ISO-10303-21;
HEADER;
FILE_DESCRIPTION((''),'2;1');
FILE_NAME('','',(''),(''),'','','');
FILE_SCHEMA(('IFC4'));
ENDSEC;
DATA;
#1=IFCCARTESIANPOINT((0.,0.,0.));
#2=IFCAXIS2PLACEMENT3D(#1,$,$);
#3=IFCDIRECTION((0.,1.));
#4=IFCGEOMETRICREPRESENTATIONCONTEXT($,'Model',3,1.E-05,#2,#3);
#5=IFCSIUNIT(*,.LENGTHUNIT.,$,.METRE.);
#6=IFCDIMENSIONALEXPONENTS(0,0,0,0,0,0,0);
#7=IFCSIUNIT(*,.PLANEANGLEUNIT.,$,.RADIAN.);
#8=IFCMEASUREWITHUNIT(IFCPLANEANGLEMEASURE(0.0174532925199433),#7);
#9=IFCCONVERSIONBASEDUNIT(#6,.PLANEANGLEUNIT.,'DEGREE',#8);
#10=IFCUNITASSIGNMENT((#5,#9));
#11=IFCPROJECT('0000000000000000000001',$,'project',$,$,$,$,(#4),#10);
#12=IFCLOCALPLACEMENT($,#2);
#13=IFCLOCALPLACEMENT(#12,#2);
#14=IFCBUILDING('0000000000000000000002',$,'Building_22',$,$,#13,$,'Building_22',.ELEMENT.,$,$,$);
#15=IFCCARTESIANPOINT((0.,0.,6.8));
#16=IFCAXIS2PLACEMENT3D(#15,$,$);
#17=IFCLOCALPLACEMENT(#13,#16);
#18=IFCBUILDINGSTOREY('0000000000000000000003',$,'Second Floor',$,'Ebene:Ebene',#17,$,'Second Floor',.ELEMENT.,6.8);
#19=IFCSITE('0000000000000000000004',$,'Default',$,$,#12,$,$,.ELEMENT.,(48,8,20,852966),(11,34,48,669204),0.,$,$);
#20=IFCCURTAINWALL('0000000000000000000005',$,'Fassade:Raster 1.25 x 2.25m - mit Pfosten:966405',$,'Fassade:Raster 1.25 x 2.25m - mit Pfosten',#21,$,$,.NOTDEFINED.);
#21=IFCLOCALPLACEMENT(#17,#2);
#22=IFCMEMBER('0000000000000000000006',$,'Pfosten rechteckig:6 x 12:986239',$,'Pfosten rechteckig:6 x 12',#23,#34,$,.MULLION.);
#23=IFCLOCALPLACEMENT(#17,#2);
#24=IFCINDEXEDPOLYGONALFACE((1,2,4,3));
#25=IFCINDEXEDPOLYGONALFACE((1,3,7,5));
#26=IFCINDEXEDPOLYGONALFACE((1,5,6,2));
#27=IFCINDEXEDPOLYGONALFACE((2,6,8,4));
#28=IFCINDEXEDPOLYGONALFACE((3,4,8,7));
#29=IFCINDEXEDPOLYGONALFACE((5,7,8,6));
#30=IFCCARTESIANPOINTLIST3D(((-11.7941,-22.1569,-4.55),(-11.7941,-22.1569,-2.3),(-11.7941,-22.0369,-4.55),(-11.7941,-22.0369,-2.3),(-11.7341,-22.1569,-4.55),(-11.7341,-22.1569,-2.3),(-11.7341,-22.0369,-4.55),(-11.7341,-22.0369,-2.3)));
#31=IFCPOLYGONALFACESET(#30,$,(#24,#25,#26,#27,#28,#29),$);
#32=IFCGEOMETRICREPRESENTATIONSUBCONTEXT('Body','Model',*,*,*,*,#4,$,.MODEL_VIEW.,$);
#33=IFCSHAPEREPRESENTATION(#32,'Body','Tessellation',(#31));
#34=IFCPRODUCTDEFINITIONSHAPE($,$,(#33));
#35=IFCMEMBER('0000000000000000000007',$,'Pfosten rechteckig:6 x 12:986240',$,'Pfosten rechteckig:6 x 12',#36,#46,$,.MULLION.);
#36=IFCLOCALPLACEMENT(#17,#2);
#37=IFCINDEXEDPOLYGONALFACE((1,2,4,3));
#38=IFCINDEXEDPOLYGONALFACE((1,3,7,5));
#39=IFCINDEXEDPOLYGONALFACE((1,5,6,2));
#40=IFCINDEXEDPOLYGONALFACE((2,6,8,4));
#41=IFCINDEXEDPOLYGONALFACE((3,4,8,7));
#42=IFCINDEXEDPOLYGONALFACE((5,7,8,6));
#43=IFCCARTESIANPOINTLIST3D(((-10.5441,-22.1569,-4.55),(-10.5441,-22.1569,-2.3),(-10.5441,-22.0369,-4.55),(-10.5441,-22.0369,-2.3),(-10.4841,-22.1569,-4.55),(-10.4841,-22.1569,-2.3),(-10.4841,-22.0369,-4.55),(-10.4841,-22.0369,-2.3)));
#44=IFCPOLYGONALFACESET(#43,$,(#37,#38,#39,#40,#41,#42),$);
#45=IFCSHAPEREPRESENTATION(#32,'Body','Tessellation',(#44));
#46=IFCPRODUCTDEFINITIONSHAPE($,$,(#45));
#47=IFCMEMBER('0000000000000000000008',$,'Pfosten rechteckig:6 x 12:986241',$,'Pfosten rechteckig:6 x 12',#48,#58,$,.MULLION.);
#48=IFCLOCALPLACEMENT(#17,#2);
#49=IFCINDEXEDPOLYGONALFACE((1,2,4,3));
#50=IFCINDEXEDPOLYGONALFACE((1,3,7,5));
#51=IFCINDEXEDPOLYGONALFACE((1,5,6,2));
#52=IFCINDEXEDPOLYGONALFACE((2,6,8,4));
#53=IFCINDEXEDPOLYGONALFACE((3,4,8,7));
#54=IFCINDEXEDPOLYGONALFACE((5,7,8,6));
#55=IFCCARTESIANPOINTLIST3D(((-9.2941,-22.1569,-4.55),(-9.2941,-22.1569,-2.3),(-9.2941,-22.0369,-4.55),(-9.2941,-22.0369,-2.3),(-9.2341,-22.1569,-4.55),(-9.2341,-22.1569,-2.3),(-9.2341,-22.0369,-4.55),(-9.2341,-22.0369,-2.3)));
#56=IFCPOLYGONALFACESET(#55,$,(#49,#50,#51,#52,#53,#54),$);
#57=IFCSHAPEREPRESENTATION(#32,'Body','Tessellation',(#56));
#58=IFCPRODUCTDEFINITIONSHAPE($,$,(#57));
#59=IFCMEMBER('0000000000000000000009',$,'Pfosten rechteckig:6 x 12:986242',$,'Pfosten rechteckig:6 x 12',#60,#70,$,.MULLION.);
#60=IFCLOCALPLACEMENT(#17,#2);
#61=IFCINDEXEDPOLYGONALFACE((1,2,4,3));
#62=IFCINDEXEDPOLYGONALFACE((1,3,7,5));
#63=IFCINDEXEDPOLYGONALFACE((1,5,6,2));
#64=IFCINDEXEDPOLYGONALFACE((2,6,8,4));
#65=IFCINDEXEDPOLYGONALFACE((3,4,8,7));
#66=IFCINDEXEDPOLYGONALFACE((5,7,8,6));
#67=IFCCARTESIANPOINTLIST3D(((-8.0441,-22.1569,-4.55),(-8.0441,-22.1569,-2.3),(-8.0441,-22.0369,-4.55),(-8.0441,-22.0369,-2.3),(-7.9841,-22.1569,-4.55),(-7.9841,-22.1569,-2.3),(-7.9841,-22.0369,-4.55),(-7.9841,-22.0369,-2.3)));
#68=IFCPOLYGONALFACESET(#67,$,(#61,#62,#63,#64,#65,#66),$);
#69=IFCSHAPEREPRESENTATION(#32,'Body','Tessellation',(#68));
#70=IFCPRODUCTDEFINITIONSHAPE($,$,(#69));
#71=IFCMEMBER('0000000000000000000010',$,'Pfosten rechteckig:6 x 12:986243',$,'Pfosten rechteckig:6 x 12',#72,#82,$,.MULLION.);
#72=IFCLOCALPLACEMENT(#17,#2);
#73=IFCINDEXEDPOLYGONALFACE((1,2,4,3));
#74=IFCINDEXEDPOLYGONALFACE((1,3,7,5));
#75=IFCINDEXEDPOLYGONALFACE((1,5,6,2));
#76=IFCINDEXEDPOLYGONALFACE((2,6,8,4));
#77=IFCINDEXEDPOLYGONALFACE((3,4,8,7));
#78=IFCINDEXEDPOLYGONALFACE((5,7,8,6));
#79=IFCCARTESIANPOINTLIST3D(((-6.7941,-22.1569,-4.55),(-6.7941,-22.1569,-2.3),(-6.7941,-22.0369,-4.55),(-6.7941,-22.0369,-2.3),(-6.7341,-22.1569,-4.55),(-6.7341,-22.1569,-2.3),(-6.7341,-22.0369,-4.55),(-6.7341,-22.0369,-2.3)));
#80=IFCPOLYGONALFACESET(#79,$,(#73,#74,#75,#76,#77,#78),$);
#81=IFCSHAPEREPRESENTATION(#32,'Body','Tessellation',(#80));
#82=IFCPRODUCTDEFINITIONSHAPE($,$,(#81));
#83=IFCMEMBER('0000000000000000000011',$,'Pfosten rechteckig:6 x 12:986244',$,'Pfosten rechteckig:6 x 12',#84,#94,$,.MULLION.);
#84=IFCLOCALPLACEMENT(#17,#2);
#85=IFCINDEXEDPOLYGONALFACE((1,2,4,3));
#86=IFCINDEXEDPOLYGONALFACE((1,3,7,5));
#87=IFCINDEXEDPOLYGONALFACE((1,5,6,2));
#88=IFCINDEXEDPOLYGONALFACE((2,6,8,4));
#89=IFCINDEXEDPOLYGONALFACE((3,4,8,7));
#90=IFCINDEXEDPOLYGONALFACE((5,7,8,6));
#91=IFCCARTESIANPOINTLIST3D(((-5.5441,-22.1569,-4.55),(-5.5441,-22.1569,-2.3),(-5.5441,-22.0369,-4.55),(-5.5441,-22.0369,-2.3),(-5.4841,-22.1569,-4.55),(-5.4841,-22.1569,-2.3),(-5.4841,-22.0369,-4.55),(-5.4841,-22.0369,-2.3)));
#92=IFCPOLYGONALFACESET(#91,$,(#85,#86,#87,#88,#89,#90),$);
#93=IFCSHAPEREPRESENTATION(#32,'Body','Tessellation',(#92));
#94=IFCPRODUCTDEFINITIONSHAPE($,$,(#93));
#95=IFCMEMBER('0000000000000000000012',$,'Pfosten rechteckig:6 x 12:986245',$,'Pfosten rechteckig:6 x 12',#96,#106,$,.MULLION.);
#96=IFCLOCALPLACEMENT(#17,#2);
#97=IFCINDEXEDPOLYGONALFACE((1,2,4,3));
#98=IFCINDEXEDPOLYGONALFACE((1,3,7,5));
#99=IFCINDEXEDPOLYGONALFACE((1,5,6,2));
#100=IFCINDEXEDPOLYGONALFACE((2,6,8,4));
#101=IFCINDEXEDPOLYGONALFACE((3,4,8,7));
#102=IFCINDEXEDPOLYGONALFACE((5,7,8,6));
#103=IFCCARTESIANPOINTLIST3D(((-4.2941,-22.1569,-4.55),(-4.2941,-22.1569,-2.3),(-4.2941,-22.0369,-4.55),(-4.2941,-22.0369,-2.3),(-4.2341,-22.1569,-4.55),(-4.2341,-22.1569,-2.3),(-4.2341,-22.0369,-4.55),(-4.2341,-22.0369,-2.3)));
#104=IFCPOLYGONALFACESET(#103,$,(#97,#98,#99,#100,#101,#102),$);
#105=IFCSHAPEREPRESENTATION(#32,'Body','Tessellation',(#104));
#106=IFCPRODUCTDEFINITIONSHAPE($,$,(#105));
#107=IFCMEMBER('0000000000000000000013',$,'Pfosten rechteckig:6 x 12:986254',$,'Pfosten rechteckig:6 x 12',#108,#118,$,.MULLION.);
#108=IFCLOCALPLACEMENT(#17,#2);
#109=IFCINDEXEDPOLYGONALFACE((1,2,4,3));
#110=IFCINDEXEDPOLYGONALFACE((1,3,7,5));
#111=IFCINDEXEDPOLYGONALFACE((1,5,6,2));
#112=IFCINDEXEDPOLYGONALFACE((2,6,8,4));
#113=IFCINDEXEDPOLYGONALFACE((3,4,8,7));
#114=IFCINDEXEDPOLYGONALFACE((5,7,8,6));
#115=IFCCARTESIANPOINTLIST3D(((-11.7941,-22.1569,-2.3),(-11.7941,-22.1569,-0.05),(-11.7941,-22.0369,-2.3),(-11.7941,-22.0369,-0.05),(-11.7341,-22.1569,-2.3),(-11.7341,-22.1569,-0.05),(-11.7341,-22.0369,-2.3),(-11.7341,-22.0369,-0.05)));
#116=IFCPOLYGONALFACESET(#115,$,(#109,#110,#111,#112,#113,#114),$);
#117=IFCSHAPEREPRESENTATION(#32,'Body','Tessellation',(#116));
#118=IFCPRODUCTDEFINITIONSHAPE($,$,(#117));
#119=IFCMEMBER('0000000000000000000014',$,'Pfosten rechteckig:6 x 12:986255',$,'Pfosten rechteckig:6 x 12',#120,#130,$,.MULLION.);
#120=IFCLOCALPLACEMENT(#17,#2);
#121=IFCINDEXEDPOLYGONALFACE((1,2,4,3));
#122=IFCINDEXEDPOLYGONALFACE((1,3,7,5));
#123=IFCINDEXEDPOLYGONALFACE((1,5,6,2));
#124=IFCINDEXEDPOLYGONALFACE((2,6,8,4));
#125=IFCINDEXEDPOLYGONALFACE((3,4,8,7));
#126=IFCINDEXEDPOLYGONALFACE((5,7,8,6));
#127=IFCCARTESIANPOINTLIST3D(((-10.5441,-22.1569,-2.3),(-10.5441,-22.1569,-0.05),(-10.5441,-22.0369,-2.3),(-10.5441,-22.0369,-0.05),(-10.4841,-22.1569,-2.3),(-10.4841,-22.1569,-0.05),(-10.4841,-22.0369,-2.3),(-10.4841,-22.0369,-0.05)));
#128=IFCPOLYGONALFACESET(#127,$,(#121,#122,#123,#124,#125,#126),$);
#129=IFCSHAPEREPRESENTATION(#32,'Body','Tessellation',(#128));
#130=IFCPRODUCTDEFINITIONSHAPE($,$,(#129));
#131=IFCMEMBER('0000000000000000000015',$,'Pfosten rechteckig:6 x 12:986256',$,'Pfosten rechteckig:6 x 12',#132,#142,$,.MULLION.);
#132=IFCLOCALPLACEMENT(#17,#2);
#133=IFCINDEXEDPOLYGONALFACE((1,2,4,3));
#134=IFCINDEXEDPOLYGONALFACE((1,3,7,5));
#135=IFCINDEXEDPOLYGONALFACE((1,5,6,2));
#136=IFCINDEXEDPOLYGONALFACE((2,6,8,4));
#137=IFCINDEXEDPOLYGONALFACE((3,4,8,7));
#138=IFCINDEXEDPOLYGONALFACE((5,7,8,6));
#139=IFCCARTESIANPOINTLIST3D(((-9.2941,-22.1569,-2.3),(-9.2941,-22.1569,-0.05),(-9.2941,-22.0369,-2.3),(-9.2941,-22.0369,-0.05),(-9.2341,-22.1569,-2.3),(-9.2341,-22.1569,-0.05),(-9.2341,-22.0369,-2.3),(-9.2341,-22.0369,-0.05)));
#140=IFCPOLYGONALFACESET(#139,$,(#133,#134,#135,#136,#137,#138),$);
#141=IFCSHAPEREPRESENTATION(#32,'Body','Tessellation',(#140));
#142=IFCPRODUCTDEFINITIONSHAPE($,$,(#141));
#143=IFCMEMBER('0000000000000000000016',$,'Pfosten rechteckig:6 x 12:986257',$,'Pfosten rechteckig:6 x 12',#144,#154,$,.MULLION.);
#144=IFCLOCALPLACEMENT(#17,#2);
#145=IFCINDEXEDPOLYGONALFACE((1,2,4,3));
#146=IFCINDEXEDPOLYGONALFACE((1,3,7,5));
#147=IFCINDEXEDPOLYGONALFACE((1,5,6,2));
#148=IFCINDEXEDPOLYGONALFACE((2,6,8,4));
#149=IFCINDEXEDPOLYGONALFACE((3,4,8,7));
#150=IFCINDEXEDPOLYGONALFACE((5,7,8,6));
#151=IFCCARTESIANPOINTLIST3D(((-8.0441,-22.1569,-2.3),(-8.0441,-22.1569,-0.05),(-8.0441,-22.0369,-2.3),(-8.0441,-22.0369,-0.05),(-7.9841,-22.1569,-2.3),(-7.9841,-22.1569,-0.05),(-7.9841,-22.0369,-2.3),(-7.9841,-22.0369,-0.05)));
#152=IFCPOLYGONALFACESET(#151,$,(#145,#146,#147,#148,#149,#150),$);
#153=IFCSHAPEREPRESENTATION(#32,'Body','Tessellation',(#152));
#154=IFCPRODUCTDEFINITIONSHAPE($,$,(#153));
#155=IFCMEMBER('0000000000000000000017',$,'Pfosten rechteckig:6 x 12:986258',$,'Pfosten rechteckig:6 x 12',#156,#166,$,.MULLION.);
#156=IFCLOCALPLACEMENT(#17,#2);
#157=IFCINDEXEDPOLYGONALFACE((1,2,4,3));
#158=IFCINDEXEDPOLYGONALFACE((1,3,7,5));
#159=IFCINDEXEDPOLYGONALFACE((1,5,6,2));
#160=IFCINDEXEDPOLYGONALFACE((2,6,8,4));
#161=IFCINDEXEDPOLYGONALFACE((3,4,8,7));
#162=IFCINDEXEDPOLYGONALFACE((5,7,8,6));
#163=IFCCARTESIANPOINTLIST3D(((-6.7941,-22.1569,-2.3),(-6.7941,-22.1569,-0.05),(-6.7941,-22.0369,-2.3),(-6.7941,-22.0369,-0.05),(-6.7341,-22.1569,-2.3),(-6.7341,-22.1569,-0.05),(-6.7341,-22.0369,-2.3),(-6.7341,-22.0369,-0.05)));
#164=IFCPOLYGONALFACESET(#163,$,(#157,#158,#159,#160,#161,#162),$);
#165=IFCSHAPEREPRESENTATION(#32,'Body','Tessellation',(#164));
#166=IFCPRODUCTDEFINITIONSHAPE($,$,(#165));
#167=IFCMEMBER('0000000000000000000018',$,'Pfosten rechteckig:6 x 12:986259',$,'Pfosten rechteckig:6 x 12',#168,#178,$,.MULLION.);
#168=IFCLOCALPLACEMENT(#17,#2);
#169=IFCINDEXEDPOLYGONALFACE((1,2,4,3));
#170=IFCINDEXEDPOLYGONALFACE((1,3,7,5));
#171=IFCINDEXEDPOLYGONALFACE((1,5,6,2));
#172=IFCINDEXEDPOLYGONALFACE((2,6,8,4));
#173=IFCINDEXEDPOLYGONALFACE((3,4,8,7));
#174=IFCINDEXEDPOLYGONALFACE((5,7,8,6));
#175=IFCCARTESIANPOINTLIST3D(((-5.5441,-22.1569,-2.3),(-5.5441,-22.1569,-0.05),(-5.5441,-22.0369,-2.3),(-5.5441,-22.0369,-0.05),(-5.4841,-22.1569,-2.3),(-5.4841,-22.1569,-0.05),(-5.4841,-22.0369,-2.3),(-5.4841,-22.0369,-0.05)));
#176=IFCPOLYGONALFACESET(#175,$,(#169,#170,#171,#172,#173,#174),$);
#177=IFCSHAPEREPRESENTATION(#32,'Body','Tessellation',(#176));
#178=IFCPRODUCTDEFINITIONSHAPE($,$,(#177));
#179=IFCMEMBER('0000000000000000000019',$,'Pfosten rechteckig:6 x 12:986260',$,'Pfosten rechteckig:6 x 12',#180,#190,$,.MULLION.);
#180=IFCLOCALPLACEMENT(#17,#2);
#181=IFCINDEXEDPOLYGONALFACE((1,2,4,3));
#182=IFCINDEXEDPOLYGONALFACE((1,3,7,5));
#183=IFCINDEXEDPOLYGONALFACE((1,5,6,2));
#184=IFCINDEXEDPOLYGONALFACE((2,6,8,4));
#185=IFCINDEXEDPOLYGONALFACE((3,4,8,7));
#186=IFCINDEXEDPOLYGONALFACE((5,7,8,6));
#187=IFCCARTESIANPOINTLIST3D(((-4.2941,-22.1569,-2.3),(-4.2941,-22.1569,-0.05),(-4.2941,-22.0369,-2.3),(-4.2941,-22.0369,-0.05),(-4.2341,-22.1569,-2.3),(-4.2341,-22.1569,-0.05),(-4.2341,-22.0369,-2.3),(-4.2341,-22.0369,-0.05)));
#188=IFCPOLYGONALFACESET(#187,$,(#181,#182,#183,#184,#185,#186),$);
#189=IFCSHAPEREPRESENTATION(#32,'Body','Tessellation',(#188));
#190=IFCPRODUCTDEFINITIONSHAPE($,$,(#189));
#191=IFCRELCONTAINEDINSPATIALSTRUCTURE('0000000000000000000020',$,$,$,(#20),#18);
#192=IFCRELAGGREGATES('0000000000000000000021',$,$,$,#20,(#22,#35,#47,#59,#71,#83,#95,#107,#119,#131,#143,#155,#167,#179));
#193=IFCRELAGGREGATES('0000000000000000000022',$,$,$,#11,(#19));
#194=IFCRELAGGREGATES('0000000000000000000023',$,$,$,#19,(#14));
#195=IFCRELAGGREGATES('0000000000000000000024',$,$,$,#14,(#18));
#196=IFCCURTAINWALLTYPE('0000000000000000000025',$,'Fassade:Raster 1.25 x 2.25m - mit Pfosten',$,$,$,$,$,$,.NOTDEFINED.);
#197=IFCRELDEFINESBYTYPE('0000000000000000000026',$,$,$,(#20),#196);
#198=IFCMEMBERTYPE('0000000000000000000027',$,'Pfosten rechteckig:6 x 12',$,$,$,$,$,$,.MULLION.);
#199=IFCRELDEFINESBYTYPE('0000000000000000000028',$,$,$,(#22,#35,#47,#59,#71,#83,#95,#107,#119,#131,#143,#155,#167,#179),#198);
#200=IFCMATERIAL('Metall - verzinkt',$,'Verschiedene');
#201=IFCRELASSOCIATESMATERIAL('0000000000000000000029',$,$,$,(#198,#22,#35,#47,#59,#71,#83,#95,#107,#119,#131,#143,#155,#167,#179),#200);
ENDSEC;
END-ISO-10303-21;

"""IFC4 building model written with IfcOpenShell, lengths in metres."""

from ifc_helpers import new_model, entity, si_unit, converted_unit, direction, frame, origin, place, context, subcontext, project, spatial, indexed_curve, outline, extrude, source, transform, mapped, material, type_object, type_shapes, element, aggregate, save


model = new_model("IFC4")

# Units and contexts
model_context = context("Model", 3, precision=1e-05, world=origin(), true_north=direction((0.0, 1.0)))
body_context = subcontext(model_context, "Body", "Model", "MODEL_VIEW")
ifc_project = project(units=[si_unit("LENGTHUNIT", "METRE"), converted_unit("PLANEANGLEUNIT", "DEGREE", entity("IfcPlaneAngleMeasure", 0.0174532925199433), si_unit("PLANEANGLEUNIT", "RADIAN"), dimensions=[0, 0, 0, 0, 0, 0, 0])], contexts=[model_context])

# Site, building, storey
site_placement = place(None, origin())
site = spatial("IfcSite", under=ifc_project, at=site_placement, Name="Default", CompositionType="ELEMENT", RefLatitude=(48, 8, 20, 852966), RefLongitude=(11, 34, 48, 669204), RefElevation=0.0)
building_placement = place(site_placement, origin())
building = spatial("IfcBuilding", under=site, at=building_placement, Name="Building_22", LongName="Building_22", CompositionType="ELEMENT")
storey_placement = place(building_placement, frame((0.0, 0.0, 6.8)))
storey = spatial("IfcBuildingStorey", under=building, at=storey_placement, Name="Second Floor", ObjectType="Ebene:Ebene", LongName="Second Floor", CompositionType="ELEMENT", Elevation=6.8)

# Curtain wall, members
curtain_wall_type = type_object("IfcCurtainWallType", Name="Fassade:Raster 1.25 x 2.25m - mit Pfosten", PredefinedType="NOTDEFINED")
curtain_wall_placement = place(storey_placement, frame((0.0, 0.0, -6.8)))
curtain_wall = element("IfcCurtainWall", 1, at=curtain_wall_placement, inside=storey, type_object=curtain_wall_type, Name="Fassade:Raster 1.25 x 2.25m - mit Pfosten:966405", ObjectType="Fassade:Raster 1.25 x 2.25m - mit Pfosten", PredefinedType="NOTDEFINED")
ifc_material = material(Name="Metall - verzinkt", Category="Verschiedene")
member_type_1 = type_object("IfcMemberType", Name="Pfosten rechteckig:6 x 12", PredefinedType="MULLION", material=ifc_material)
shared_shape_1 = source(origin(), body_context, "Body", "SweptSolid", [
    extrude(outline(indexed_curve([(-0.03, -0.06), (0.03, -0.06), (0.03, 0.06), (-0.03, 0.06), (-0.03, -0.06)], self_intersect=False)), frame((0.0, 0.0, -2.25), z_axis=(0.0, 0.0, 1.0), x_axis=(-1.0, 0.0, 0.0)), (0.0, 0.0, 1.0), 2.25),
])
type_shapes(member_type_1, [shared_shape_1])
member_1_placement = place(curtain_wall_placement, frame((-11.7641, -22.0969, 2.25), z_axis=(0.0, 0.0, -1.0), x_axis=(1.0, 0.0, 0.0)))
member_1 = element("IfcMember", 2, at=member_1_placement, type_object=member_type_1, material=ifc_material, Name="Pfosten rechteckig:6 x 12:986239", ObjectType="Pfosten rechteckig:6 x 12", PredefinedType="MULLION", context=body_context, shape_type="MappedRepresentation", body=[
    mapped(shared_shape_1, transform((0.0, 0.0, 0.0), scale=1.0)),
])
member_2_placement = place(curtain_wall_placement, frame((-10.5141, -22.0969, 2.25), z_axis=(0.0, 0.0, -1.0), x_axis=(1.0, 0.0, 0.0)))
member_2 = element("IfcMember", 3, at=member_2_placement, type_object=member_type_1, material=ifc_material, Name="Pfosten rechteckig:6 x 12:986240", ObjectType="Pfosten rechteckig:6 x 12", PredefinedType="MULLION", context=body_context, shape_type="MappedRepresentation", body=[
    mapped(shared_shape_1, transform((0.0, 0.0, 0.0), scale=1.0)),
])
member_3_placement = place(curtain_wall_placement, frame((-9.2641, -22.0969, 2.25), z_axis=(0.0, 0.0, -1.0), x_axis=(1.0, 0.0, 0.0)))
member_3 = element("IfcMember", 4, at=member_3_placement, type_object=member_type_1, material=ifc_material, Name="Pfosten rechteckig:6 x 12:986241", ObjectType="Pfosten rechteckig:6 x 12", PredefinedType="MULLION", context=body_context, shape_type="MappedRepresentation", body=[
    mapped(shared_shape_1, transform((0.0, 0.0, 0.0), scale=1.0)),
])
member_4_placement = place(curtain_wall_placement, frame((-8.0141, -22.0969, 2.25), z_axis=(0.0, 0.0, -1.0), x_axis=(1.0, 0.0, 0.0)))
member_4 = element("IfcMember", 5, at=member_4_placement, type_object=member_type_1, material=ifc_material, Name="Pfosten rechteckig:6 x 12:986242", ObjectType="Pfosten rechteckig:6 x 12", PredefinedType="MULLION", context=body_context, shape_type="MappedRepresentation", body=[
    mapped(shared_shape_1, transform((0.0, 0.0, 0.0), scale=1.0)),
])
member_5_placement = place(curtain_wall_placement, frame((-6.7641, -22.0969, 2.25), z_axis=(0.0, 0.0, -1.0), x_axis=(1.0, 0.0, 0.0)))
member_5 = element("IfcMember", 6, at=member_5_placement, type_object=member_type_1, material=ifc_material, Name="Pfosten rechteckig:6 x 12:986243", ObjectType="Pfosten rechteckig:6 x 12", PredefinedType="MULLION", context=body_context, shape_type="MappedRepresentation", body=[
    mapped(shared_shape_1, transform((0.0, 0.0, 0.0), scale=1.0)),
])
member_6_placement = place(curtain_wall_placement, frame((-5.5141, -22.0969, 2.25), z_axis=(0.0, 0.0, -1.0), x_axis=(1.0, 0.0, 0.0)))
member_6 = element("IfcMember", 7, at=member_6_placement, type_object=member_type_1, material=ifc_material, Name="Pfosten rechteckig:6 x 12:986244", ObjectType="Pfosten rechteckig:6 x 12", PredefinedType="MULLION", context=body_context, shape_type="MappedRepresentation", body=[
    mapped(shared_shape_1, transform((0.0, 0.0, 0.0), scale=1.0)),
])
member_7_placement = place(curtain_wall_placement, frame((-4.2641, -22.0969, 2.25), z_axis=(0.0, 0.0, -1.0), x_axis=(1.0, 0.0, 0.0)))
member_7 = element("IfcMember", 8, at=member_7_placement, type_object=member_type_1, material=ifc_material, Name="Pfosten rechteckig:6 x 12:986245", ObjectType="Pfosten rechteckig:6 x 12", PredefinedType="MULLION", context=body_context, shape_type="MappedRepresentation", body=[
    mapped(shared_shape_1, transform((0.0, 0.0, 0.0), scale=1.0)),
])
member_8_placement = place(curtain_wall_placement, frame((-11.7641, -22.0969, 4.5), z_axis=(0.0, 0.0, -1.0), x_axis=(1.0, 0.0, 0.0)))
member_8 = element("IfcMember", 9, at=member_8_placement, type_object=member_type_1, material=ifc_material, Name="Pfosten rechteckig:6 x 12:986254", ObjectType="Pfosten rechteckig:6 x 12", PredefinedType="MULLION", context=body_context, shape_type="MappedRepresentation", body=[
    mapped(shared_shape_1, transform((0.0, 0.0, 0.0), scale=1.0)),
])
member_9_placement = place(curtain_wall_placement, frame((-10.5141, -22.0969, 4.5), z_axis=(0.0, 0.0, -1.0), x_axis=(1.0, 0.0, 0.0)))
member_9 = element("IfcMember", 10, at=member_9_placement, type_object=member_type_1, material=ifc_material, Name="Pfosten rechteckig:6 x 12:986255", ObjectType="Pfosten rechteckig:6 x 12", PredefinedType="MULLION", context=body_context, shape_type="MappedRepresentation", body=[
    mapped(shared_shape_1, transform((0.0, 0.0, 0.0), scale=1.0)),
])
member_10_placement = place(curtain_wall_placement, frame((-9.2641, -22.0969, 4.5), z_axis=(0.0, 0.0, -1.0), x_axis=(1.0, 0.0, 0.0)))
member_10 = element("IfcMember", 11, at=member_10_placement, type_object=member_type_1, material=ifc_material, Name="Pfosten rechteckig:6 x 12:986256", ObjectType="Pfosten rechteckig:6 x 12", PredefinedType="MULLION", context=body_context, shape_type="MappedRepresentation", body=[
    mapped(shared_shape_1, transform((0.0, 0.0, 0.0), scale=1.0)),
])
member_11_placement = place(curtain_wall_placement, frame((-8.0141, -22.0969, 4.5), z_axis=(0.0, 0.0, -1.0), x_axis=(1.0, 0.0, 0.0)))
member_11 = element("IfcMember", 12, at=member_11_placement, type_object=member_type_1, material=ifc_material, Name="Pfosten rechteckig:6 x 12:986257", ObjectType="Pfosten rechteckig:6 x 12", PredefinedType="MULLION", context=body_context, shape_type="MappedRepresentation", body=[
    mapped(shared_shape_1, transform((0.0, 0.0, 0.0), scale=1.0)),
])
member_12_placement = place(curtain_wall_placement, frame((-6.7641, -22.0969, 4.5), z_axis=(0.0, 0.0, -1.0), x_axis=(1.0, 0.0, 0.0)))
member_12 = element("IfcMember", 13, at=member_12_placement, type_object=member_type_1, material=ifc_material, Name="Pfosten rechteckig:6 x 12:986258", ObjectType="Pfosten rechteckig:6 x 12", PredefinedType="MULLION", context=body_context, shape_type="MappedRepresentation", body=[
    mapped(shared_shape_1, transform((0.0, 0.0, 0.0), scale=1.0)),
])
member_13_placement = place(curtain_wall_placement, frame((-5.5141, -22.0969, 4.5), z_axis=(0.0, 0.0, -1.0), x_axis=(1.0, 0.0, 0.0)))
member_13 = element("IfcMember", 14, at=member_13_placement, type_object=member_type_1, material=ifc_material, Name="Pfosten rechteckig:6 x 12:986259", ObjectType="Pfosten rechteckig:6 x 12", PredefinedType="MULLION", context=body_context, shape_type="MappedRepresentation", body=[
    mapped(shared_shape_1, transform((0.0, 0.0, 0.0), scale=1.0)),
])
member_14_placement = place(curtain_wall_placement, frame((-4.2641, -22.0969, 4.5), z_axis=(0.0, 0.0, -1.0), x_axis=(1.0, 0.0, 0.0)))
member_14 = element("IfcMember", 15, at=member_14_placement, type_object=member_type_1, material=ifc_material, Name="Pfosten rechteckig:6 x 12:986260", ObjectType="Pfosten rechteckig:6 x 12", PredefinedType="MULLION", context=body_context, shape_type="MappedRepresentation", body=[
    mapped(shared_shape_1, transform((0.0, 0.0, 0.0), scale=1.0)),
])
aggregate(curtain_wall, [member_1, member_2, member_3, member_4, member_5, member_6, member_7, member_8, member_9, member_10, member_11, member_12, member_13, member_14])

save(model, "model.ifc")
